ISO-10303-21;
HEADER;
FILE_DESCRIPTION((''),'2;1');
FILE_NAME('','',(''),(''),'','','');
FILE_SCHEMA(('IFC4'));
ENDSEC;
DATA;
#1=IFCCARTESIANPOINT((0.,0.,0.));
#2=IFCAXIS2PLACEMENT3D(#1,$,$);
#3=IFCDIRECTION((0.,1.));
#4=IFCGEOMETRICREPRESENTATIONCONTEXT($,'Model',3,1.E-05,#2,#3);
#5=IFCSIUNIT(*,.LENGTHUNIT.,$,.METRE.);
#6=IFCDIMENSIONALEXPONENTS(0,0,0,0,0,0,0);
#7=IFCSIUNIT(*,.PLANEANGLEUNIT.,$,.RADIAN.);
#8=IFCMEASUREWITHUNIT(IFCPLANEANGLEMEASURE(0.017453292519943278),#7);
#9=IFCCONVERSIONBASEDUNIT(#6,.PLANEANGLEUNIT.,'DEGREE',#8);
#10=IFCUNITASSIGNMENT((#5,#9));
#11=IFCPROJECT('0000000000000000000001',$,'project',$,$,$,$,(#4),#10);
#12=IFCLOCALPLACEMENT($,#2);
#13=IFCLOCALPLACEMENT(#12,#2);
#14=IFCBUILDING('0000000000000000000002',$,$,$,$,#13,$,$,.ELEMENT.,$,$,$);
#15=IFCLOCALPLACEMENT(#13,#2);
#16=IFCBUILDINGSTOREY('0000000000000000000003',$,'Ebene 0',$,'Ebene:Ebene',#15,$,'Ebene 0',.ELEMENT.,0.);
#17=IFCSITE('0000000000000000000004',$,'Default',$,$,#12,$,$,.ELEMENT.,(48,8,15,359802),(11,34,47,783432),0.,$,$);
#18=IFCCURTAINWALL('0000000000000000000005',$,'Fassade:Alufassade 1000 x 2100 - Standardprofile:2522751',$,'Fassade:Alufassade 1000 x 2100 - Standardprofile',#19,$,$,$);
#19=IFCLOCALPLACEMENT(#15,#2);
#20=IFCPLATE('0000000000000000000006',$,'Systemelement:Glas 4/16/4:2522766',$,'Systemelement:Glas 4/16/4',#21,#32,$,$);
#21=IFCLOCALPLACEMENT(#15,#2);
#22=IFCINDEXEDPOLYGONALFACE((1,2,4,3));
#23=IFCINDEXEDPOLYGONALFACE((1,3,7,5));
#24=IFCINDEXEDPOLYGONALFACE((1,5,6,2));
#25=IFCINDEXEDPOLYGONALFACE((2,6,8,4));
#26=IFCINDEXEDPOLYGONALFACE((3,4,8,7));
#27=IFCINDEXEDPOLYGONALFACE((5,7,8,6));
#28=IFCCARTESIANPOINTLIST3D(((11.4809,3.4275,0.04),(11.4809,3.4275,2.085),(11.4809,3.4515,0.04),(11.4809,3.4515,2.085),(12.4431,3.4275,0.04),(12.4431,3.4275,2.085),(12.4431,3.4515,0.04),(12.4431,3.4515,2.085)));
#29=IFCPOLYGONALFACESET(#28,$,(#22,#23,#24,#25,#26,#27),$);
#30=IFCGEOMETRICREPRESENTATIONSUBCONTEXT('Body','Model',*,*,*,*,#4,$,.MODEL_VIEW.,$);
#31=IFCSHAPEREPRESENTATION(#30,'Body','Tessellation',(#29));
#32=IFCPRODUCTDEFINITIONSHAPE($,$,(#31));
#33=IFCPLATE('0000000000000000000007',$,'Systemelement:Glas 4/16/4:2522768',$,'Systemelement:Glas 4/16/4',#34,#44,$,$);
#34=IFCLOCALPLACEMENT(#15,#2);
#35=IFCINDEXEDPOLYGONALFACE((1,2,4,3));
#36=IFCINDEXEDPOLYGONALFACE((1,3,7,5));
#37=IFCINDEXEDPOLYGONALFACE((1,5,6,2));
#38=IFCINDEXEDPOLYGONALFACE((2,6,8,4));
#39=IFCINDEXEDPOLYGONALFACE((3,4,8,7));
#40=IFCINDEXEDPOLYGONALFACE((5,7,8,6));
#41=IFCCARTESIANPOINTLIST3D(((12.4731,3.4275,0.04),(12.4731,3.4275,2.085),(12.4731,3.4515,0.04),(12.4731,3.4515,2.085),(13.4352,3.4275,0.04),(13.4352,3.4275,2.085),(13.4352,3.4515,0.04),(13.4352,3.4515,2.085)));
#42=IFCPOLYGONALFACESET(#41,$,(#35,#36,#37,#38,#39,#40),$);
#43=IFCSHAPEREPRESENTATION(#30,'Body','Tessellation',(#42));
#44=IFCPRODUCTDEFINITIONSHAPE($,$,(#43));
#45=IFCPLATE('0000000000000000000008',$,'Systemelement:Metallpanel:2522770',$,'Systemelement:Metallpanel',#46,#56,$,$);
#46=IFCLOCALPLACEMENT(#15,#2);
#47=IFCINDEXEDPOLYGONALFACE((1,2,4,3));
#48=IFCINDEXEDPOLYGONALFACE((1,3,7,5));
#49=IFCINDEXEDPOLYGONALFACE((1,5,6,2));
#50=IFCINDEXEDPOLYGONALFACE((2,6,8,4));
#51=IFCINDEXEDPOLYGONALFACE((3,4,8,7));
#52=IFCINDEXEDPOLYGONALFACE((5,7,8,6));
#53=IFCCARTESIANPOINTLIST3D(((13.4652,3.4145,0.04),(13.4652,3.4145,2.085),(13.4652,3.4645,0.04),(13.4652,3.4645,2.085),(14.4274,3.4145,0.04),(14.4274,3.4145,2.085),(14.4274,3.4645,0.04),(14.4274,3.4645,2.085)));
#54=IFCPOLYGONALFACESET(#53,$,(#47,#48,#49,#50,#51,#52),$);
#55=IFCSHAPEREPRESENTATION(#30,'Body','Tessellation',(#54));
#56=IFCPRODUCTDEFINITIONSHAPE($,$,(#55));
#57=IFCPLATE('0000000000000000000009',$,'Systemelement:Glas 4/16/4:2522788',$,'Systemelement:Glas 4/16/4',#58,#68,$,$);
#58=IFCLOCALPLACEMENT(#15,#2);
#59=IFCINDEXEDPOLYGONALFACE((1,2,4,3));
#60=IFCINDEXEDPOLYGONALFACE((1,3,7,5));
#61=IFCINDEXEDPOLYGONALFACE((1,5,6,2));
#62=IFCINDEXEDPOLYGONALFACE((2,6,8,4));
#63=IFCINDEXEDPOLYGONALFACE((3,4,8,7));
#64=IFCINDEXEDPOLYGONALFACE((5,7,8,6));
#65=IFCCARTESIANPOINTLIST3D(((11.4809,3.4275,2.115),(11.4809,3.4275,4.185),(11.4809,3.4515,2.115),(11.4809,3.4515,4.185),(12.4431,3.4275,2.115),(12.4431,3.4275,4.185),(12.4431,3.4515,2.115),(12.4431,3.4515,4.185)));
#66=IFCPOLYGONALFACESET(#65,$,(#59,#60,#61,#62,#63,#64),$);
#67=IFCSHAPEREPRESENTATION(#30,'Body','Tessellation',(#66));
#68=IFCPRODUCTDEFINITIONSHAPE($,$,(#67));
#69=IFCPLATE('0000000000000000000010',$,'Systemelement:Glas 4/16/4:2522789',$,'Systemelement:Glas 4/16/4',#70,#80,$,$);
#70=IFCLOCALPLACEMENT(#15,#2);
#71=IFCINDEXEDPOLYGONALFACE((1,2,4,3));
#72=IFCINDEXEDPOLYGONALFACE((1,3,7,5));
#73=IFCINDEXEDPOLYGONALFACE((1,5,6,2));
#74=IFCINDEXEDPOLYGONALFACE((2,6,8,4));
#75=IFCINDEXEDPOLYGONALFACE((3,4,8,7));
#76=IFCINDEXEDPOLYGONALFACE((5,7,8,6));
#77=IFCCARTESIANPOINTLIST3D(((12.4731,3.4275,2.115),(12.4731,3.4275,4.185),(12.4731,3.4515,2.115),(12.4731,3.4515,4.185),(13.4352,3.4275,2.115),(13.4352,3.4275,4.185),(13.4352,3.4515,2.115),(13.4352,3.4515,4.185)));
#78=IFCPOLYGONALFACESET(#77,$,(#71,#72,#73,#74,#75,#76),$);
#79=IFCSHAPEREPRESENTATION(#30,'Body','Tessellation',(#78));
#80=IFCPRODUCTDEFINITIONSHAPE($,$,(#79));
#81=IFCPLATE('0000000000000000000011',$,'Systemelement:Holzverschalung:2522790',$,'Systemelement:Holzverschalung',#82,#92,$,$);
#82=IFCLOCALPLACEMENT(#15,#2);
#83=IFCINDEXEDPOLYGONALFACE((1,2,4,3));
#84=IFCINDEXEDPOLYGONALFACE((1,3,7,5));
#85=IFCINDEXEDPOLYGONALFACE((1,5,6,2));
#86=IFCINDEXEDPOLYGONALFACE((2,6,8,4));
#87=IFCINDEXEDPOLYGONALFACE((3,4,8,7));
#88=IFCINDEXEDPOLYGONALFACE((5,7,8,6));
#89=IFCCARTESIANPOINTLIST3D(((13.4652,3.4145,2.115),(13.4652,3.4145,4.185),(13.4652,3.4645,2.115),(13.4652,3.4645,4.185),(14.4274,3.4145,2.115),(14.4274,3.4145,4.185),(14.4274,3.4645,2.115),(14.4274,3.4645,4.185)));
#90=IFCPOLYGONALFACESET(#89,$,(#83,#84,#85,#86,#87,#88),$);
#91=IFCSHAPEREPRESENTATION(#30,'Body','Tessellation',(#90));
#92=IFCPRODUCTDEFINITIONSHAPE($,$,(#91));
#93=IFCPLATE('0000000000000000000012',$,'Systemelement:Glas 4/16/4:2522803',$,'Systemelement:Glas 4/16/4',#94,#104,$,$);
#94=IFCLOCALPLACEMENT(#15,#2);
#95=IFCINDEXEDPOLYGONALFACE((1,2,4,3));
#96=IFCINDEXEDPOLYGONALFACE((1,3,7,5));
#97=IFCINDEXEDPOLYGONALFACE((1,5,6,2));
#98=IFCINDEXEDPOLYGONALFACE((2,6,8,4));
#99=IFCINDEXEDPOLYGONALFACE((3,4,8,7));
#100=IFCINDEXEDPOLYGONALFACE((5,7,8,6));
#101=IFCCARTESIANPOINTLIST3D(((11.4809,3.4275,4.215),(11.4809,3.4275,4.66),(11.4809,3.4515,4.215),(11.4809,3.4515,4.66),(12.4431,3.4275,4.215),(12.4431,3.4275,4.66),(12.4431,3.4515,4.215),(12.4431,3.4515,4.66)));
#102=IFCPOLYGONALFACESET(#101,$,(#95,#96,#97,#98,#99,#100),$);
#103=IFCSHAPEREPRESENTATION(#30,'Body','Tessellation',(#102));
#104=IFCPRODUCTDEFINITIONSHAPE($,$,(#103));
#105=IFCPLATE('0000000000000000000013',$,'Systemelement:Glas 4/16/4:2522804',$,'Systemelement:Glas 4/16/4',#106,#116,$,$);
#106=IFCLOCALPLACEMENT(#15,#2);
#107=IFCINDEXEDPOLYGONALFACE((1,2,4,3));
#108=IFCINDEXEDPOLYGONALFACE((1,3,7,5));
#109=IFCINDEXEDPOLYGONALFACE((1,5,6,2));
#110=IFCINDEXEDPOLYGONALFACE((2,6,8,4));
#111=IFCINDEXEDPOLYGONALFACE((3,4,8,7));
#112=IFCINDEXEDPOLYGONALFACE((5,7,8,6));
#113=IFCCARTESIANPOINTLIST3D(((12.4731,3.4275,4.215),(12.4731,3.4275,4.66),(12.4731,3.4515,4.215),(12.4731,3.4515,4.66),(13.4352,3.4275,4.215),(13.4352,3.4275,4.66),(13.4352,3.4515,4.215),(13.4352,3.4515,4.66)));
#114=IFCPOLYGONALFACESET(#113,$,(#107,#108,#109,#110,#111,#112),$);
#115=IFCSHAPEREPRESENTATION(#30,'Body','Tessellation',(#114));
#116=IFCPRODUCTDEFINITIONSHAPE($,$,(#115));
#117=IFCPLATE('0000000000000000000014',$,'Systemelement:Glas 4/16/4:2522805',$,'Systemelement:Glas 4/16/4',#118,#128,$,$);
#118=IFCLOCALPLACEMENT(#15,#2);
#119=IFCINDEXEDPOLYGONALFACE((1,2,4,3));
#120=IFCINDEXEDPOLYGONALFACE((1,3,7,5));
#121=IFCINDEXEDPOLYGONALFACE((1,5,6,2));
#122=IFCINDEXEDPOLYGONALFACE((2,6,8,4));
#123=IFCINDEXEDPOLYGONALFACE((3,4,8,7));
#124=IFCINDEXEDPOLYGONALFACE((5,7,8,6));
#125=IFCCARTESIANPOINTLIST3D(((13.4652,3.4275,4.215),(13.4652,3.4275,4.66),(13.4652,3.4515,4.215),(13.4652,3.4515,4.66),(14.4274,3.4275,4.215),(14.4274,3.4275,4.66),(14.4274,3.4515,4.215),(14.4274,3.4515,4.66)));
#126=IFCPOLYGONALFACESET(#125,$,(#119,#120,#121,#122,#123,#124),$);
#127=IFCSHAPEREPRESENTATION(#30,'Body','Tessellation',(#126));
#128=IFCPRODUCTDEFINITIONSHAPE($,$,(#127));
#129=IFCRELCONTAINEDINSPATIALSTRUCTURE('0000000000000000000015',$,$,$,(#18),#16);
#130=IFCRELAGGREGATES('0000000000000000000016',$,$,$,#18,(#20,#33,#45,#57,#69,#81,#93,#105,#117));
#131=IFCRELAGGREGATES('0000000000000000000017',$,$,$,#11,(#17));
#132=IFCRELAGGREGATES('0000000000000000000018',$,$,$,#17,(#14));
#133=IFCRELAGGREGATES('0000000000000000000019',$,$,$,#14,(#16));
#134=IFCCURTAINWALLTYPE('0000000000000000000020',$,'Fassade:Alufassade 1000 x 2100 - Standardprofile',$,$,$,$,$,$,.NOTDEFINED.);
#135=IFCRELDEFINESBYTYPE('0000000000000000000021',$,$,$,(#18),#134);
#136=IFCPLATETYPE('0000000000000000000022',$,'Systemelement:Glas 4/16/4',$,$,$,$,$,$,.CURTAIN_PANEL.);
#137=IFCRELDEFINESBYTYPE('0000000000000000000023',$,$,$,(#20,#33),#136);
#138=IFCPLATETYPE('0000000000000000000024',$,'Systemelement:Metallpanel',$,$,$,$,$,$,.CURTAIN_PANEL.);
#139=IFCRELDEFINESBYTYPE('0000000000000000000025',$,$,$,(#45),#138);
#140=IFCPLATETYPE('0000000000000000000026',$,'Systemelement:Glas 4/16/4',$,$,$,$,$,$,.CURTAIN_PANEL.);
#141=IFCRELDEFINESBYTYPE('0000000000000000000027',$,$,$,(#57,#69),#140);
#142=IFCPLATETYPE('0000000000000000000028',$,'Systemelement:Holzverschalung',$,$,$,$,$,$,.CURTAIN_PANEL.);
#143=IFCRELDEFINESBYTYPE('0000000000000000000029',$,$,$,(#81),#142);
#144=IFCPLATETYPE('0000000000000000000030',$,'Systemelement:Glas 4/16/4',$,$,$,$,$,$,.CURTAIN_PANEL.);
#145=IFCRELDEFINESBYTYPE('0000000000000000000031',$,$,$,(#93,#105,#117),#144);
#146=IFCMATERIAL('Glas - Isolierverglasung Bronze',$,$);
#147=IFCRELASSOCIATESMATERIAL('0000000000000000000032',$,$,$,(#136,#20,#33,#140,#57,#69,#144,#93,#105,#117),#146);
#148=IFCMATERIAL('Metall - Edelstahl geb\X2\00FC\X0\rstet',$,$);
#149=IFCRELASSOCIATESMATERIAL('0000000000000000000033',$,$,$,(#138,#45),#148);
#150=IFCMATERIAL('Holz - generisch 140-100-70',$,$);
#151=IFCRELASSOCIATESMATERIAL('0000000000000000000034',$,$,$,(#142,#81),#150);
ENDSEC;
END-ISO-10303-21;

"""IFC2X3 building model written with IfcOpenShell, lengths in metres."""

from ifc_helpers import new_model, entity, si_unit, converted_unit, direction, frame, origin, origin_2d_with_axis, place, context, subcontext, project, spatial, rectangle, extrude, source, transform, mapped, material, type_object, type_shapes, element, aggregate, save


model = new_model("IFC2X3")

# Units and contexts
model_context = context("Model", 3, precision=1e-05, world=origin(), true_north=direction((0.0, 1.0)))
body_context = subcontext(model_context, "Body", "Model", "MODEL_VIEW")
ifc_project = project(units=[si_unit("LENGTHUNIT", "METRE"), converted_unit("PLANEANGLEUNIT", "DEGREE", entity("IfcPlaneAngleMeasure", 0.017453292519943278), si_unit("PLANEANGLEUNIT", "RADIAN"), dimensions=[0, 0, 0, 0, 0, 0, 0])], contexts=[model_context])

# Site, building, storey
site_placement = place(None, origin())
site = spatial("IfcSite", under=ifc_project, at=site_placement, Name="Default", CompositionType="ELEMENT", RefLatitude=(48, 8, 15, 359802), RefLongitude=(11, 34, 47, 783432), RefElevation=0.0)
building_placement = place(site_placement, origin())
building = spatial("IfcBuilding", under=site, at=building_placement, CompositionType="ELEMENT")
storey_placement = place(building_placement, origin())
storey = spatial("IfcBuildingStorey", under=building, at=storey_placement, Name="Ebene 0", ObjectType="Ebene:Ebene", LongName="Ebene 0", CompositionType="ELEMENT", Elevation=0.0)

# Curtain wall, plates
curtain_wall_type = type_object("IfcCurtainWallType", Name="Fassade:Alufassade 1000 x 2100 - Standardprofile", PredefinedType="NOTDEFINED")
curtain_wall_placement = place(storey_placement, origin())
curtain_wall = element("IfcCurtainWall", 1, at=curtain_wall_placement, inside=storey, type_object=curtain_wall_type, Name="Fassade:Alufassade 1000 x 2100 - Standardprofile:2522751", ObjectType="Fassade:Alufassade 1000 x 2100 - Standardprofile")
ifc_material_1 = material(Name="Glas - Isolierverglasung Bronze")
plate_type_1 = type_object("IfcPlateType", Name="Systemelement:Glas 4/16/4", PredefinedType="CURTAIN_PANEL", material=ifc_material_1)
shared_shape_1 = source(origin(), body_context, "Body", "SweptSolid", [
    extrude(rectangle(XDim=0.024, YDim=0.9621, at=origin_2d_with_axis()), frame((0.0, 0.0, 0.0), z_axis=(0.0, 0.0, 1.0), x_axis=(0.0, 1.0, 0.0)), (0.0, 0.0, 1.0), 2.045),
])
type_shapes(plate_type_1, [shared_shape_1])
plate_1_placement = place(curtain_wall_placement, frame((11.962, 3.4395, 0.04)))
plate_1 = element("IfcPlate", 2, at=plate_1_placement, type_object=plate_type_1, material=ifc_material_1, Name="Systemelement:Glas 4/16/4:2522766", ObjectType="Systemelement:Glas 4/16/4", context=body_context, shape_type="MappedRepresentation", body=[
    mapped(shared_shape_1, transform((0.0, 0.0, 0.0), scale=1.0)),
])
plate_2_placement = place(curtain_wall_placement, frame((12.9542, 3.4395, 0.04)))
plate_2 = element("IfcPlate", 3, at=plate_2_placement, type_object=plate_type_1, material=ifc_material_1, Name="Systemelement:Glas 4/16/4:2522768", ObjectType="Systemelement:Glas 4/16/4", context=body_context, shape_type="MappedRepresentation", body=[
    mapped(shared_shape_1, transform((0.0, 0.0, 0.0), scale=1.0)),
])
ifc_material_2 = material(Name="Metall - Edelstahl gebürstet")
plate_type_2 = type_object("IfcPlateType", Name="Systemelement:Metallpanel", PredefinedType="CURTAIN_PANEL", material=ifc_material_2)
shared_shape_2 = source(origin(), body_context, "Body", "SweptSolid", [
    extrude(rectangle(XDim=0.05, YDim=0.9621, at=origin_2d_with_axis()), frame((0.0, 0.0, 0.0), z_axis=(0.0, 0.0, 1.0), x_axis=(0.0, 1.0, 0.0)), (0.0, 0.0, 1.0), 2.045),
])
type_shapes(plate_type_2, [shared_shape_2])
plate_3_placement = place(curtain_wall_placement, frame((13.9463, 3.4395, 0.04)))
plate_3 = element("IfcPlate", 4, at=plate_3_placement, type_object=plate_type_2, material=ifc_material_2, Name="Systemelement:Metallpanel:2522770", ObjectType="Systemelement:Metallpanel", context=body_context, shape_type="MappedRepresentation", body=[
    mapped(shared_shape_2, transform((0.0, 0.0, 0.0), scale=1.0)),
])
plate_type_3 = type_object("IfcPlateType", Name="Systemelement:Glas 4/16/4", PredefinedType="CURTAIN_PANEL", material=ifc_material_1)
shared_shape_3 = source(origin(), body_context, "Body", "SweptSolid", [
    extrude(rectangle(XDim=0.024, YDim=0.9621, at=origin_2d_with_axis()), frame((0.0, 0.0, 0.0), z_axis=(0.0, 0.0, 1.0), x_axis=(0.0, 1.0, 0.0)), (0.0, 0.0, 1.0), 2.07),
])
type_shapes(plate_type_3, [shared_shape_3])
plate_4_placement = place(curtain_wall_placement, frame((11.962, 3.4395, 2.115)))
plate_4 = element("IfcPlate", 5, at=plate_4_placement, type_object=plate_type_3, material=ifc_material_1, Name="Systemelement:Glas 4/16/4:2522788", ObjectType="Systemelement:Glas 4/16/4", context=body_context, shape_type="MappedRepresentation", body=[
    mapped(shared_shape_3, transform((0.0, 0.0, 0.0), scale=1.0)),
])
plate_5_placement = place(curtain_wall_placement, frame((12.9542, 3.4395, 2.115)))
plate_5 = element("IfcPlate", 6, at=plate_5_placement, type_object=plate_type_3, material=ifc_material_1, Name="Systemelement:Glas 4/16/4:2522789", ObjectType="Systemelement:Glas 4/16/4", context=body_context, shape_type="MappedRepresentation", body=[
    mapped(shared_shape_3, transform((0.0, 0.0, 0.0), scale=1.0)),
])
ifc_material_3 = material(Name="Holz - generisch 140-100-70")
plate_type_4 = type_object("IfcPlateType", Name="Systemelement:Holzverschalung", PredefinedType="CURTAIN_PANEL", material=ifc_material_3)
shared_shape_4 = source(origin(), body_context, "Body", "SweptSolid", [
    extrude(rectangle(XDim=0.05, YDim=0.9621, at=origin_2d_with_axis()), frame((0.0, 0.0, 0.0), z_axis=(0.0, 0.0, 1.0), x_axis=(0.0, 1.0, 0.0)), (0.0, 0.0, 1.0), 2.07),
])
type_shapes(plate_type_4, [shared_shape_4])
plate_6_placement = place(curtain_wall_placement, frame((13.9463, 3.4395, 2.115)))
plate_6 = element("IfcPlate", 7, at=plate_6_placement, type_object=plate_type_4, material=ifc_material_3, Name="Systemelement:Holzverschalung:2522790", ObjectType="Systemelement:Holzverschalung", context=body_context, shape_type="MappedRepresentation", body=[
    mapped(shared_shape_4, transform((0.0, 0.0, 0.0), scale=1.0)),
])
plate_type_5 = type_object("IfcPlateType", Name="Systemelement:Glas 4/16/4", PredefinedType="CURTAIN_PANEL", material=ifc_material_1)
shared_shape_5 = source(origin(), body_context, "Body", "SweptSolid", [
    extrude(rectangle(XDim=0.024, YDim=0.9621, at=origin_2d_with_axis()), frame((0.0, 0.0, 0.0), z_axis=(0.0, 0.0, 1.0), x_axis=(0.0, 1.0, 0.0)), (0.0, 0.0, 1.0), 0.445),
])
type_shapes(plate_type_5, [shared_shape_5])
plate_7_placement = place(curtain_wall_placement, frame((11.962, 3.4395, 4.215)))
plate_7 = element("IfcPlate", 8, at=plate_7_placement, type_object=plate_type_5, material=ifc_material_1, Name="Systemelement:Glas 4/16/4:2522803", ObjectType="Systemelement:Glas 4/16/4", context=body_context, shape_type="MappedRepresentation", body=[
    mapped(shared_shape_5, transform((0.0, 0.0, 0.0), scale=1.0)),
])
plate_8_placement = place(curtain_wall_placement, frame((12.9542, 3.4395, 4.215)))
plate_8 = element("IfcPlate", 9, at=plate_8_placement, type_object=plate_type_5, material=ifc_material_1, Name="Systemelement:Glas 4/16/4:2522804", ObjectType="Systemelement:Glas 4/16/4", context=body_context, shape_type="MappedRepresentation", body=[
    mapped(shared_shape_5, transform((0.0, 0.0, 0.0), scale=1.0)),
])
plate_9_placement = place(curtain_wall_placement, frame((13.9463, 3.4395, 4.215)))
plate_9 = element("IfcPlate", 10, at=plate_9_placement, type_object=plate_type_5, material=ifc_material_1, Name="Systemelement:Glas 4/16/4:2522805", ObjectType="Systemelement:Glas 4/16/4", context=body_context, shape_type="MappedRepresentation", body=[
    mapped(shared_shape_5, transform((0.0, 0.0, 0.0), scale=1.0)),
])
aggregate(curtain_wall, [plate_1, plate_2, plate_3, plate_4, plate_5, plate_6, plate_7, plate_8, plate_9])

save(model, "model.ifc")
